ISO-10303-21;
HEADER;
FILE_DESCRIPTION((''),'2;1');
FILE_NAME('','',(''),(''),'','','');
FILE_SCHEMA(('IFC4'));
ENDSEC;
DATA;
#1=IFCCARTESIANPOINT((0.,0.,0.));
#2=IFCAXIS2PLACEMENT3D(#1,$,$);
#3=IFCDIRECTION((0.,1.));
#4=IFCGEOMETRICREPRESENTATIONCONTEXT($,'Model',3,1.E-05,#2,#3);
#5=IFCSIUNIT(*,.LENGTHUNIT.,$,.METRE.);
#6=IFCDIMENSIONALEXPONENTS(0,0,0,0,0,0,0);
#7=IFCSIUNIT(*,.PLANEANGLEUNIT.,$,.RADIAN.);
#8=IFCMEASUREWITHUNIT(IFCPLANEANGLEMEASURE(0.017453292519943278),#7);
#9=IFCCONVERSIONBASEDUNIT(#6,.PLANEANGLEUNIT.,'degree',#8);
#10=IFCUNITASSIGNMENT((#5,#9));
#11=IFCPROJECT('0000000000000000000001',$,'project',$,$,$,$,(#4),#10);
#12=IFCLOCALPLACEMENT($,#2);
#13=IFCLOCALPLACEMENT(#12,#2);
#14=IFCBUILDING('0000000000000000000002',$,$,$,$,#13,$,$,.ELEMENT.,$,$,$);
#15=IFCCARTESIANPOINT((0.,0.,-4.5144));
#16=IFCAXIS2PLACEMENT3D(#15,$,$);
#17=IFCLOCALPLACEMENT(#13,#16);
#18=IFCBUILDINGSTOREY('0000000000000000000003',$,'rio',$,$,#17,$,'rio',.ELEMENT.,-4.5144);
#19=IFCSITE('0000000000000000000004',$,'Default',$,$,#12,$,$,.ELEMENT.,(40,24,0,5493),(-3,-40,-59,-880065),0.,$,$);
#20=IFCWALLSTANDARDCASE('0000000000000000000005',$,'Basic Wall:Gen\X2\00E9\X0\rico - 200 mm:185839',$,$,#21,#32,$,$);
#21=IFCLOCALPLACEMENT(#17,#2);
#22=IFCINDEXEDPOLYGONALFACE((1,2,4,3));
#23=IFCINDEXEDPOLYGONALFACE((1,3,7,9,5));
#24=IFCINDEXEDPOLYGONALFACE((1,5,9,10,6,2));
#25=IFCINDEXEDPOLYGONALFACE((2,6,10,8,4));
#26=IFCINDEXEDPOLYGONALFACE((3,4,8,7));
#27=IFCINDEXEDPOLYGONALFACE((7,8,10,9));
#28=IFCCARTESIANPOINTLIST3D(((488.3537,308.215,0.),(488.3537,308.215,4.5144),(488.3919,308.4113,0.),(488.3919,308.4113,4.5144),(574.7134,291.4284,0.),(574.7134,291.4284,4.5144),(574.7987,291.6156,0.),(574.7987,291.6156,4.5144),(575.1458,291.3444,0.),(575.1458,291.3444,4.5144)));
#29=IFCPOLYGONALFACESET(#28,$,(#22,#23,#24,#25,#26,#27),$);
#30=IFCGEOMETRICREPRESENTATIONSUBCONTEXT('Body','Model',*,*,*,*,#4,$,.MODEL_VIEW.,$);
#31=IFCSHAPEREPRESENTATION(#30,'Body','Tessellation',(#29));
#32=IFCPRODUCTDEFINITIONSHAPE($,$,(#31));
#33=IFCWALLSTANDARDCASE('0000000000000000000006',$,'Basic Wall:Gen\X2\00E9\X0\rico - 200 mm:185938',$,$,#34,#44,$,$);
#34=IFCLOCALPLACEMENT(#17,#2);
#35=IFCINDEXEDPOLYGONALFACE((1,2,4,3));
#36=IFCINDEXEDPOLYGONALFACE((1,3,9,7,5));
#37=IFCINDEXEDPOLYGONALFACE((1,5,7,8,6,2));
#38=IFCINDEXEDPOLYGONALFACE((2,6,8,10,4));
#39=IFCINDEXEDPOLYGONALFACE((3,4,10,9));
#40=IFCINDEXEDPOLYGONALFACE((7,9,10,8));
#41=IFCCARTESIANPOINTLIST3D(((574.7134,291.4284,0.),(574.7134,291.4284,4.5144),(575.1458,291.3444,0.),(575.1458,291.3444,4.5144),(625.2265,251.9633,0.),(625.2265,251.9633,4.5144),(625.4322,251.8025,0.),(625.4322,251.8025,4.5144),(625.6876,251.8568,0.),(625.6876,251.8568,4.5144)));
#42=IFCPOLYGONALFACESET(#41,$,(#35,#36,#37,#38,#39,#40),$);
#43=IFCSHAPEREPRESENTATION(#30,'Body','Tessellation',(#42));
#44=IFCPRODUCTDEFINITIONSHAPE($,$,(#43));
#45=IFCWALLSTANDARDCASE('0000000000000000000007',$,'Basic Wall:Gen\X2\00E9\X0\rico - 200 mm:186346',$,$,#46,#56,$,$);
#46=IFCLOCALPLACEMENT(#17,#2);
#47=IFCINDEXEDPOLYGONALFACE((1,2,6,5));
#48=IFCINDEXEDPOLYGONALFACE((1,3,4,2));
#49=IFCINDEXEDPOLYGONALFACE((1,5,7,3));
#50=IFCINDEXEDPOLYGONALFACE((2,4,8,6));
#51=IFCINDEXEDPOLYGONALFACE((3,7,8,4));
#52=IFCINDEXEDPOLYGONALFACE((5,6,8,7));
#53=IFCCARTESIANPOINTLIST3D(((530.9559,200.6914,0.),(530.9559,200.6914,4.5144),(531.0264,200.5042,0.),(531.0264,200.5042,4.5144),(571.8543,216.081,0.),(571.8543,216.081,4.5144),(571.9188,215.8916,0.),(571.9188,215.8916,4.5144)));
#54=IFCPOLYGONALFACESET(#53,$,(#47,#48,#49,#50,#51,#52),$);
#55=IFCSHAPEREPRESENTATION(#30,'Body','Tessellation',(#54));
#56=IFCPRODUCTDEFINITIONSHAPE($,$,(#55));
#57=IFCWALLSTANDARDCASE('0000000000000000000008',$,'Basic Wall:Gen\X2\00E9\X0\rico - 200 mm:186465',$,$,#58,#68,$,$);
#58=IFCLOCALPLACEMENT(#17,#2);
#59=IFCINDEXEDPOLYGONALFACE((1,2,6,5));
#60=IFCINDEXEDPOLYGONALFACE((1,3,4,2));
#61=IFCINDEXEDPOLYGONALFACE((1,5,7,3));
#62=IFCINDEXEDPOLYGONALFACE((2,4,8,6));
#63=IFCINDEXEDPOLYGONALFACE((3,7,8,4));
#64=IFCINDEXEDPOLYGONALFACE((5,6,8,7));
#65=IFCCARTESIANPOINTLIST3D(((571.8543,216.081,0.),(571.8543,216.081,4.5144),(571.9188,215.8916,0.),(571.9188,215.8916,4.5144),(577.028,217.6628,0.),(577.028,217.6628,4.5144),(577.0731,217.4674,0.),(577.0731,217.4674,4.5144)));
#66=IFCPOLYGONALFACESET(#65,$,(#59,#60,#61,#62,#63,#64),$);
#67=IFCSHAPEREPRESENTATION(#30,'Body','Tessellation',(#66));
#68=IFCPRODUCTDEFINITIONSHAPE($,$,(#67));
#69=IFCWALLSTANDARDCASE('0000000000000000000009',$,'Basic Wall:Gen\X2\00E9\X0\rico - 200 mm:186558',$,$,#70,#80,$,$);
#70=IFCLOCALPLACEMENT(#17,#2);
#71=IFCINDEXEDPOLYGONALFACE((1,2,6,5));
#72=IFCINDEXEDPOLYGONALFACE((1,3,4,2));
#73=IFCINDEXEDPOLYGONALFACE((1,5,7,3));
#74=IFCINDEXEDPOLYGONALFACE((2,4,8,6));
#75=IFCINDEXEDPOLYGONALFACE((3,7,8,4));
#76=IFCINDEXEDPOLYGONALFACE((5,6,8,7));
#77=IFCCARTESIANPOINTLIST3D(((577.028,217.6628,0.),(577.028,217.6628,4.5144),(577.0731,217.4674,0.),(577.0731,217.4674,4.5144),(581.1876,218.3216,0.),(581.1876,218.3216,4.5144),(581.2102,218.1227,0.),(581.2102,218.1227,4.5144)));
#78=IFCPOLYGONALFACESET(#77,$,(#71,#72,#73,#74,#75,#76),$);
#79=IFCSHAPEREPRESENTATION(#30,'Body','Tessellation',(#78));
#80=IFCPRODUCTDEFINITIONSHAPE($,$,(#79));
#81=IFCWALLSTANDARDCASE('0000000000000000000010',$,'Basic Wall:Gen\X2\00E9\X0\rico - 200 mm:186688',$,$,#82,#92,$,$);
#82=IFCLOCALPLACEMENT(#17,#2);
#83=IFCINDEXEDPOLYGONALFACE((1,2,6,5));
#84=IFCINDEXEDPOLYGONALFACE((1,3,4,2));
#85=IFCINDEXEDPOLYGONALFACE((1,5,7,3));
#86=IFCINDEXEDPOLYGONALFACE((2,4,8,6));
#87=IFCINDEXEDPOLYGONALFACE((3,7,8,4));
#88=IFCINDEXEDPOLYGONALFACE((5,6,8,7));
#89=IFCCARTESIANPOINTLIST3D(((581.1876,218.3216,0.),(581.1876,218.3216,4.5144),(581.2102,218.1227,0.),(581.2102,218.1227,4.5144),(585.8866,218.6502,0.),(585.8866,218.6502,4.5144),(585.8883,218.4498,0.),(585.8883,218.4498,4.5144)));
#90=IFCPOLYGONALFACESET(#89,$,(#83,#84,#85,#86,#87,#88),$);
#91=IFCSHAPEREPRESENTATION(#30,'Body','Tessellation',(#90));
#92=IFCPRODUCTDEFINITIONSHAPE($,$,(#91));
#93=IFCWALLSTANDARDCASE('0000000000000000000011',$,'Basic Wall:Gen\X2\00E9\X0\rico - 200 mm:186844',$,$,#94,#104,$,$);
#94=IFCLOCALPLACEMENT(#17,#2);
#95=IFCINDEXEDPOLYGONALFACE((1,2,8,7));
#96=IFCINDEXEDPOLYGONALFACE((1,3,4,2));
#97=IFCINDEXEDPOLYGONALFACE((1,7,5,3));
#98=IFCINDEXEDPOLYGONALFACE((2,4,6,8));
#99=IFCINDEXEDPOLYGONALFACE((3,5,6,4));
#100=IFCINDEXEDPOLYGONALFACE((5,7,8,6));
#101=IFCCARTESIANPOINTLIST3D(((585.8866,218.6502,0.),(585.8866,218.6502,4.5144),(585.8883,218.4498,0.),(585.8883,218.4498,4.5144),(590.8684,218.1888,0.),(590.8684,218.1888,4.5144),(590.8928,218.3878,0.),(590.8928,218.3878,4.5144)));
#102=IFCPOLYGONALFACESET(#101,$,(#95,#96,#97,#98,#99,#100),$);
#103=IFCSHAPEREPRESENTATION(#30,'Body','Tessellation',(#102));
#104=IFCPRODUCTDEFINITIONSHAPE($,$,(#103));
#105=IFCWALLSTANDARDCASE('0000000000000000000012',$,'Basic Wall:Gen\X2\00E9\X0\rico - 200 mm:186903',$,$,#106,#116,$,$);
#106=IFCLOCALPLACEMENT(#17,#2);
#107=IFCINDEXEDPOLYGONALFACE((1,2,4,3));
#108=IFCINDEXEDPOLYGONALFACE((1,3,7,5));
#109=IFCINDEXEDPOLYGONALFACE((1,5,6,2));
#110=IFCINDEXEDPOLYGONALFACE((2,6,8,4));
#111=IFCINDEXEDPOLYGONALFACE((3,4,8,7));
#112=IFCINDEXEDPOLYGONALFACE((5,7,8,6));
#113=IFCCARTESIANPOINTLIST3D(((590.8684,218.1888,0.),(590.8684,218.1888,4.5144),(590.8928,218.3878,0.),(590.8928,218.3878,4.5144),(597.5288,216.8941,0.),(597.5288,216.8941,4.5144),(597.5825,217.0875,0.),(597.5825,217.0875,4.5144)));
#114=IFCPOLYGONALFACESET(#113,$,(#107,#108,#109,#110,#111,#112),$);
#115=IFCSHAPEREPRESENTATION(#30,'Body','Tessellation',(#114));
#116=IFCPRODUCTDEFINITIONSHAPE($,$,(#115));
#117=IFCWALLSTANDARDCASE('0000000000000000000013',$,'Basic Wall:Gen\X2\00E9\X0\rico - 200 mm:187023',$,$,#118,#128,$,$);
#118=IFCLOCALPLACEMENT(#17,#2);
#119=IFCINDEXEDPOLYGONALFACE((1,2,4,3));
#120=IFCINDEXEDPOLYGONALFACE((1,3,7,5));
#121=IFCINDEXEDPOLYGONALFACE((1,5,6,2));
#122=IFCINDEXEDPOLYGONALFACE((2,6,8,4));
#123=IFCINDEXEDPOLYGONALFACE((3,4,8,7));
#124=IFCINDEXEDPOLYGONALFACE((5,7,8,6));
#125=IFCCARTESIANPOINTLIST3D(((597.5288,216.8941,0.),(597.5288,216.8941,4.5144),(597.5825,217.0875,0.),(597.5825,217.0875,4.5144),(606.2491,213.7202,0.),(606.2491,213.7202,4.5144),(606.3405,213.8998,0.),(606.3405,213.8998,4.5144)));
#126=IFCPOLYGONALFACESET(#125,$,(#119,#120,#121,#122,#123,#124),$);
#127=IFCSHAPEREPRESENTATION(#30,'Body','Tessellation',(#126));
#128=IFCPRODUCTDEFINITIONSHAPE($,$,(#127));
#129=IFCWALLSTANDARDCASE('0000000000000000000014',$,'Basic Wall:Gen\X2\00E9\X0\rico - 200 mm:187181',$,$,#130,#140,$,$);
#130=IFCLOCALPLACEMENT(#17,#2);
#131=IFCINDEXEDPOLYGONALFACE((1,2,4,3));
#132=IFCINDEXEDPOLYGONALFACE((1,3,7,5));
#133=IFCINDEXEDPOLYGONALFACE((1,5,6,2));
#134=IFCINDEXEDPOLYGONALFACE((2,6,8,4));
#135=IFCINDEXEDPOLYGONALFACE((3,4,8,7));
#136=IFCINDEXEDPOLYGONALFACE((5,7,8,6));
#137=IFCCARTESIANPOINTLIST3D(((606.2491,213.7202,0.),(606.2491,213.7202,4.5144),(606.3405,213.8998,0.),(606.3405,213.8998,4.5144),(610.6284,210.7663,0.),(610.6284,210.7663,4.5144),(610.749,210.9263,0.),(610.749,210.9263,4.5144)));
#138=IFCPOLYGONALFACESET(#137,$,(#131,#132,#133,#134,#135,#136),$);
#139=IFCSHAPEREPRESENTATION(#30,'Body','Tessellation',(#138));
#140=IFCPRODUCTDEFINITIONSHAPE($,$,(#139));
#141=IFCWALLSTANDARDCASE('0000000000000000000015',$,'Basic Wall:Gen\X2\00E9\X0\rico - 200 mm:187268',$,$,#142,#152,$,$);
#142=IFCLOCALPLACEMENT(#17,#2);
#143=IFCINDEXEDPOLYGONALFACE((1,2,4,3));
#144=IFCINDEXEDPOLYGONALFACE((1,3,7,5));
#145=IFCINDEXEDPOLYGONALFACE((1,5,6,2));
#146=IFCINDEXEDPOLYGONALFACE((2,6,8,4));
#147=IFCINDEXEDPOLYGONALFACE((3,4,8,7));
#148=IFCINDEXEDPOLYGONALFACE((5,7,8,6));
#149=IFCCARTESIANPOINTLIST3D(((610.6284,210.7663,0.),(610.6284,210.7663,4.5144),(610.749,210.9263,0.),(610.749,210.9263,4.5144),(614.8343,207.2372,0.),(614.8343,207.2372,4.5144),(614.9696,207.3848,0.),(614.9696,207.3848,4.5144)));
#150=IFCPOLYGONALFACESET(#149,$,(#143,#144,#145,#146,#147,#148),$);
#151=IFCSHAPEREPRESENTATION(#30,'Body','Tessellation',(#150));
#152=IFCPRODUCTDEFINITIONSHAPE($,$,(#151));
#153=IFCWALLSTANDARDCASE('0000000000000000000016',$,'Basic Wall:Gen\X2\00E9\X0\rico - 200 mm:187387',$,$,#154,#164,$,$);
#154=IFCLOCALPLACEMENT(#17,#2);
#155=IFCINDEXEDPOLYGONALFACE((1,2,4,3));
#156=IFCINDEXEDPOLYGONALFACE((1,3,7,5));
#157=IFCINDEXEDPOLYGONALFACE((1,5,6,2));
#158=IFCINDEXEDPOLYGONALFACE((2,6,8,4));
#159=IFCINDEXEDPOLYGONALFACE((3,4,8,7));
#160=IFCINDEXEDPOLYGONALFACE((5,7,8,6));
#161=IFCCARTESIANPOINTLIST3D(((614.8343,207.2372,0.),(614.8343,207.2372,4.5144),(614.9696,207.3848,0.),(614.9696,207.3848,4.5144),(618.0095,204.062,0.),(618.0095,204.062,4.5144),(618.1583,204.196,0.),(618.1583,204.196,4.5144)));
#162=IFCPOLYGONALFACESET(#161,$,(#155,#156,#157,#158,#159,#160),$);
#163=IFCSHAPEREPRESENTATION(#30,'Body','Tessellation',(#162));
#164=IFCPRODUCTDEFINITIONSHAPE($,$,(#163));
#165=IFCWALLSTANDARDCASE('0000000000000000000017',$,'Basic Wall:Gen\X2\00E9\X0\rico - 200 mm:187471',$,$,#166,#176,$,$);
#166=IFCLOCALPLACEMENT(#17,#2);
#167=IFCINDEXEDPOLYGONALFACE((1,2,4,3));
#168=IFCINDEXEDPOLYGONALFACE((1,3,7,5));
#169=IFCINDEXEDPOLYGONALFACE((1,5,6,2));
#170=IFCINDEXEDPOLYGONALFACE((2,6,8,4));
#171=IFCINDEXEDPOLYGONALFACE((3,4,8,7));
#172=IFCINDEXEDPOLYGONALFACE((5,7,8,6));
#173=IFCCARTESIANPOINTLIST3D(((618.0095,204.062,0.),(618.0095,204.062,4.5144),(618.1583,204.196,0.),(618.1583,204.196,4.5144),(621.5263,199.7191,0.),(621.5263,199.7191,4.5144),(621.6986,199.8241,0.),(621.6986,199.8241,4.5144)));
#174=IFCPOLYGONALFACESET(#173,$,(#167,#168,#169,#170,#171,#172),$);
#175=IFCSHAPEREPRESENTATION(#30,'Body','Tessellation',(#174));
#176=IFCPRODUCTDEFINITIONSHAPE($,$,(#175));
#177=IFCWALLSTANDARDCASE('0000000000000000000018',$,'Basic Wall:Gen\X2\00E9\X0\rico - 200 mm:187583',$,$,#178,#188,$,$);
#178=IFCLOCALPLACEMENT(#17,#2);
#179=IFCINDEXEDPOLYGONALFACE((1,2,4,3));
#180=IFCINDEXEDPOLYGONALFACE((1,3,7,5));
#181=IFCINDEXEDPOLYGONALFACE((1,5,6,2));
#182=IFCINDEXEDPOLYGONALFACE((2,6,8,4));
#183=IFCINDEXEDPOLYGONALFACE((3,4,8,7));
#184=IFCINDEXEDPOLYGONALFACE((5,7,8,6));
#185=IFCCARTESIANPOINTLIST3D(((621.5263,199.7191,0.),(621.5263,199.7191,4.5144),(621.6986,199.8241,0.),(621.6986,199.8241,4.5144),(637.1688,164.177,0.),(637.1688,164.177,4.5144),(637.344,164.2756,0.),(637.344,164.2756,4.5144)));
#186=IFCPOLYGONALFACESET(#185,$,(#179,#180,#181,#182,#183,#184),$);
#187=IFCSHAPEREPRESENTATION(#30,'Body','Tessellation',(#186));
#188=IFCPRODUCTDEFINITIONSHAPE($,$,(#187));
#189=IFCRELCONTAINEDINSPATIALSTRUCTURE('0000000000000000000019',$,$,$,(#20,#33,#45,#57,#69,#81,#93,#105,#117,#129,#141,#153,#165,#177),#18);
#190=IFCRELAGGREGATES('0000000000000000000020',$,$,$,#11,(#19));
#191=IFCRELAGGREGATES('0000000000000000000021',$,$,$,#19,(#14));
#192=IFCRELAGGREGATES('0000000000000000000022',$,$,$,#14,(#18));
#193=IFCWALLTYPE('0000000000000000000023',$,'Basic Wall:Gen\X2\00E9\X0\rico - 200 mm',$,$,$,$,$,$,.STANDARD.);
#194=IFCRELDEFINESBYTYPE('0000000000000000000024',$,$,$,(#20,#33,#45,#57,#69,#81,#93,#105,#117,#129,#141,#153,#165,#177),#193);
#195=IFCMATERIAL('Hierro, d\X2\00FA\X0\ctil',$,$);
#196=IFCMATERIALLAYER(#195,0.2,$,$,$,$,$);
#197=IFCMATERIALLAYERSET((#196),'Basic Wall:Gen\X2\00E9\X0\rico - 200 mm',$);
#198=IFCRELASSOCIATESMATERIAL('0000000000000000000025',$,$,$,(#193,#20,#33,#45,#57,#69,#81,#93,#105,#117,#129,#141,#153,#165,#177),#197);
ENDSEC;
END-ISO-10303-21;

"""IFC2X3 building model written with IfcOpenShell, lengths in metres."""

from ifc_helpers import new_model, entity, si_unit, converted_unit, direction, frame, origin, place, context, subcontext, project, spatial, polyline, outline, extrude, material, layer, layer_set, layer_usage, type_object, element, save


model = new_model("IFC2X3")

# Units and contexts
model_context = context("Model", 3, precision=1e-05, world=origin(), true_north=direction((0.0, 1.0)))
body_context = subcontext(model_context, "Body", "Model", "MODEL_VIEW")
ifc_project = project(units=[si_unit("LENGTHUNIT", "METRE"), converted_unit("PLANEANGLEUNIT", "degree", entity("IfcPlaneAngleMeasure", 0.017453292519943278), si_unit("PLANEANGLEUNIT", "RADIAN"), dimensions=[0, 0, 0, 0, 0, 0, 0])], contexts=[model_context])

# Site, building, storey
site_placement = place(None, origin())
site = spatial("IfcSite", under=ifc_project, at=site_placement, Name="Default", CompositionType="ELEMENT", RefLatitude=(40, 24, 0, 5493), RefLongitude=(-3, -40, -59, -880065), RefElevation=0.0)
building_placement = place(site_placement, origin())
building = spatial("IfcBuilding", under=site, at=building_placement, CompositionType="ELEMENT")
storey_placement = place(building_placement, frame((0.0, 0.0, -4.5144)))
storey = spatial("IfcBuildingStorey", under=building, at=storey_placement, Name="rio", LongName="rio", CompositionType="ELEMENT", Elevation=-4.5144)

# Walls
ifc_material_1 = material(Name="Hierro, dúctil")
ifc_layer_1 = layer(ifc_material_1, 0.2)
ifc_layer_set_1 = layer_set([ifc_layer_1], Name="Basic Wall:Genérico - 200 mm")
ifc_layer_usage_1 = layer_usage(ifc_layer_set_1, "AXIS2", "NEGATIVE", 0.1)
wall_type = type_object("IfcWallType", Name="Basic Wall:Genérico - 200 mm", PredefinedType="STANDARD", material=ifc_layer_set_1)
wall_1_placement = place(storey_placement, frame((488.3728, 308.3132, 0.0), z_axis=(0.0, 0.0, 1.0), x_axis=(0.981627, -0.190809, 0.0)))
element("IfcWallStandardCase", 1, at=wall_1_placement, inside=storey, type_object=wall_type, material=ifc_layer_usage_1, Name="Basic Wall:Genérico - 200 mm:185839", context=body_context, shape_type="SweptSolid", body=[
    extrude(outline(polyline([(88.4165, -0.1), (88.024, 0.1), (0.0, 0.1), (0.0, -0.1), (87.976, -0.1), (88.4165, -0.1)])), origin(), (0.0, 0.0, 1.0), 4.5144),
])
ifc_layer_usage_2 = layer_usage(ifc_layer_set_1, "AXIS2", "NEGATIVE", 0.1)
wall_2_placement = place(storey_placement, frame((574.7749, 291.5072, 0.0), z_axis=(0.0, 0.0, 1.0), x_axis=(0.788011, -0.615661, 0.0)))
element("IfcWallStandardCase", 2, at=wall_2_placement, inside=storey, type_object=wall_type, material=ifc_layer_usage_2, Name="Basic Wall:Genérico - 200 mm:185938", context=body_context, shape_type="SweptSolid", body=[
    extrude(outline(polyline([(64.3631, -0.1), (64.5309, 0.1), (0.3925, 0.1), (0.0, -0.1), (64.102, -0.1), (64.3631, -0.1)])), origin(), (0.0, 0.0, 1.0), 4.5144),
])
ifc_layer_usage_3 = layer_usage(ifc_layer_set_1, "AXIS2", "NEGATIVE", 0.1)
wall_3_placement = place(storey_placement, frame((530.9911, 200.5978, 0.0), z_axis=(0.0, 0.0, 1.0), x_axis=(0.935932, 0.352181, 0.0)))
element("IfcWallStandardCase", 3, at=wall_3_placement, inside=storey, type_object=wall_type, material=ifc_layer_usage_3, Name="Basic Wall:Genérico - 200 mm:186346", context=body_context, shape_type="SweptSolid", body=[
    extrude(outline(polyline([(43.6917, -0.1), (43.698, 0.1), (0.0, 0.1), (0.0, -0.1), (43.6917, -0.1)])), origin(), (0.0, 0.0, 1.0), 4.5144),
])
ifc_layer_usage_4 = layer_usage(ifc_layer_set_1, "AXIS2", "NEGATIVE", 0.1)
wall_4_placement = place(storey_placement, frame((571.8835, 215.9854, 0.0), z_axis=(0.0, 0.0, 1.0), x_axis=(0.956305, 0.292372, 0.0)))
element("IfcWallStandardCase", 4, at=wall_4_placement, inside=storey, type_object=wall_type, material=ifc_layer_usage_4, Name="Basic Wall:Genérico - 200 mm:186465", context=body_context, shape_type="SweptSolid", body=[
    extrude(outline(polyline([(5.3962, -0.1), (5.4102, 0.1), (0.0, 0.1), (0.0063, -0.1), (5.3962, -0.1)])), origin(), (0.0, 0.0, 1.0), 4.5144),
])
ifc_layer_usage_5 = layer_usage(ifc_layer_set_1, "AXIS2", "NEGATIVE", 0.1)
wall_5_placement = place(storey_placement, frame((577.0437, 217.564, 0.0), z_axis=(0.0, 0.0, 1.0), x_axis=(0.987688, 0.156434, 0.0)))
element("IfcWallStandardCase", 5, at=wall_5_placement, inside=storey, type_object=wall_type, material=ifc_layer_usage_5, Name="Basic Wall:Genérico - 200 mm:186558", context=body_context, shape_type="SweptSolid", body=[
    extrude(outline(polyline([(4.2026, -0.1), (4.2114, 0.1), (0.0, 0.1), (0.014, -0.1), (4.2026, -0.1)])), origin(), (0.0, 0.0, 1.0), 4.5144),
])
ifc_layer_usage_6 = layer_usage(ifc_layer_set_1, "AXIS2", "NEGATIVE", 0.1)
wall_6_placement = place(storey_placement, frame((581.1945, 218.2218, 0.0), z_axis=(0.0, 0.0, 1.0), x_axis=(0.997564, 0.069756, 0.0)))
element("IfcWallStandardCase", 6, at=wall_6_placement, inside=storey, type_object=wall_type, material=ifc_layer_usage_6, Name="Basic Wall:Genérico - 200 mm:186688", context=body_context, shape_type="SweptSolid", body=[
    extrude(outline(polyline([(4.6982, -0.1), (4.7105, 0.1), (0.0, 0.1), (0.0087, -0.1), (4.6982, -0.1)])), origin(), (0.0, 0.0, 1.0), 4.5144),
])
ifc_layer_usage_7 = layer_usage(ifc_layer_set_1, "AXIS2", "NEGATIVE", 0.1)
wall_7_placement = place(storey_placement, frame((585.8813, 218.5503, 0.0), z_axis=(0.0, 0.0, 1.0), x_axis=(0.99863, -0.052336, 0.0)))
element("IfcWallStandardCase", 7, at=wall_7_placement, inside=storey, type_object=wall_type, material=ifc_layer_usage_7, Name="Basic Wall:Genérico - 200 mm:186844", context=body_context, shape_type="SweptSolid", body=[
    extrude(outline(polyline([(4.9991, -0.1), (5.0131, 0.1), (0.0, 0.1), (0.0122, -0.1), (4.9991, -0.1)])), origin(), (0.0, 0.0, 1.0), 4.5144),
])
ifc_layer_usage_8 = layer_usage(ifc_layer_set_1, "AXIS2", "NEGATIVE", 0.1)
wall_8_placement = place(storey_placement, frame((590.8737, 218.2896, 0.0), z_axis=(0.0, 0.0, 1.0), x_axis=(0.981627, -0.190809, 0.0)))
element("IfcWallStandardCase", 8, at=wall_8_placement, inside=storey, type_object=wall_type, material=ifc_layer_usage_8, Name="Basic Wall:Genérico - 200 mm:186903", context=body_context, shape_type="SweptSolid", body=[
    extrude(outline(polyline([(6.7991, -0.1), (6.8149, 0.1), (0.0, 0.1), (0.014, -0.1), (6.7991, -0.1)])), origin(), (0.0, 0.0, 1.0), 4.5144),
])
ifc_layer_usage_9 = layer_usage(ifc_layer_set_1, "AXIS2", "NEGATIVE", 0.1)
wall_9_placement = place(storey_placement, frame((597.5483, 216.9935, 0.0), z_axis=(0.0, 0.0, 1.0), x_axis=(0.939693, -0.34202, 0.0)))
element("IfcWallStandardCase", 9, at=wall_9_placement, inside=storey, type_object=wall_type, material=ifc_layer_usage_9, Name="Basic Wall:Genérico - 200 mm:187023", context=body_context, shape_type="SweptSolid", body=[
    extrude(outline(polyline([(9.2956, -0.1), (9.3201, 0.1), (0.0, 0.1), (0.0157, -0.1), (9.2956, -0.1)])), origin(), (0.0, 0.0, 1.0), 4.5144),
])
ifc_layer_usage_10 = layer_usage(ifc_layer_set_1, "AXIS2", "NEGATIVE", 0.1)
wall_10_placement = place(storey_placement, frame((606.2846, 213.8169, 0.0), z_axis=(0.0, 0.0, 1.0), x_axis=(0.829038, -0.559193, 0.0)))
element("IfcWallStandardCase", 10, at=wall_10_placement, inside=storey, type_object=wall_type, material=ifc_layer_usage_10, Name="Basic Wall:Genérico - 200 mm:187181", context=body_context, shape_type="SweptSolid", body=[
    extrude(outline(polyline([(5.307, -0.1), (5.3175, 0.1), (0.0, 0.1), (0.0246, -0.1), (5.307, -0.1)])), origin(), (0.0, 0.0, 1.0), 4.5144),
])
ifc_layer_usage_11 = layer_usage(ifc_layer_set_1, "AXIS2", "NEGATIVE", 0.1)
wall_11_placement = place(storey_placement, frame((610.6847, 210.8497, 0.0), z_axis=(0.0, 0.0, 1.0), x_axis=(0.766044, -0.642788, 0.0)))
element("IfcWallStandardCase", 11, at=wall_11_placement, inside=storey, type_object=wall_type, material=ifc_layer_usage_11, Name="Basic Wall:Genérico - 200 mm:187268", context=body_context, shape_type="SweptSolid", body=[
    extrude(outline(polyline([(5.5009, -0.1), (5.5096, 0.1), (0.0, 0.1), (0.0105, -0.1), (5.5009, -0.1)])), origin(), (0.0, 0.0, 1.0), 4.5144),
])
ifc_layer_usage_12 = layer_usage(ifc_layer_set_1, "AXIS2", "NEGATIVE", 0.1)
wall_12_placement = place(storey_placement, frame((614.8988, 207.314, 0.0), z_axis=(0.0, 0.0, 1.0), x_axis=(0.707107, -0.707107, 0.0)))
element("IfcWallStandardCase", 12, at=wall_12_placement, inside=storey, type_object=wall_type, material=ifc_layer_usage_12, Name="Basic Wall:Genérico - 200 mm:187387", context=body_context, shape_type="SweptSolid", body=[
    extrude(outline(polyline([(4.4991, -0.1), (4.5096, 0.1), (0.0, 0.1), (0.0087, -0.1), (4.4991, -0.1)])), origin(), (0.0, 0.0, 1.0), 4.5144),
])
ifc_layer_usage_13 = layer_usage(ifc_layer_set_1, "AXIS2", "NEGATIVE", 0.1)
wall_13_placement = place(storey_placement, frame((618.0806, 204.1331, 0.0), z_axis=(0.0, 0.0, 1.0), x_axis=(0.62932, -0.777146, 0.0)))
element("IfcWallStandardCase", 13, at=wall_13_placement, inside=storey, type_object=wall_type, material=ifc_layer_usage_13, Name="Basic Wall:Genérico - 200 mm:187471", context=body_context, shape_type="SweptSolid", body=[
    extrude(outline(polyline([(5.5987, -0.1), (5.6255, 0.1), (0.0, 0.1), (0.0105, -0.1), (5.5987, -0.1)])), origin(), (0.0, 0.0, 1.0), 4.5144),
])
ifc_layer_usage_14 = layer_usage(ifc_layer_set_1, "AXIS2", "NEGATIVE", 0.1)
wall_14_placement = place(storey_placement, frame((621.6071, 199.7839, 0.0), z_axis=(0.0, 0.0, 1.0), x_axis=(0.402825, -0.915277, 0.0)))
element("IfcWallStandardCase", 14, at=wall_14_placement, inside=storey, type_object=wall_type, material=ifc_layer_usage_14, Name="Basic Wall:Genérico - 200 mm:187583", context=body_context, shape_type="SweptSolid", body=[
    extrude(outline(polyline([(38.8588, -0.1), (38.8392, 0.1), (0.0, 0.1), (0.0268, -0.1), (38.8588, -0.1)])), origin(), (0.0, 0.0, 1.0), 4.5144),
])

save(model, "model.ifc")
